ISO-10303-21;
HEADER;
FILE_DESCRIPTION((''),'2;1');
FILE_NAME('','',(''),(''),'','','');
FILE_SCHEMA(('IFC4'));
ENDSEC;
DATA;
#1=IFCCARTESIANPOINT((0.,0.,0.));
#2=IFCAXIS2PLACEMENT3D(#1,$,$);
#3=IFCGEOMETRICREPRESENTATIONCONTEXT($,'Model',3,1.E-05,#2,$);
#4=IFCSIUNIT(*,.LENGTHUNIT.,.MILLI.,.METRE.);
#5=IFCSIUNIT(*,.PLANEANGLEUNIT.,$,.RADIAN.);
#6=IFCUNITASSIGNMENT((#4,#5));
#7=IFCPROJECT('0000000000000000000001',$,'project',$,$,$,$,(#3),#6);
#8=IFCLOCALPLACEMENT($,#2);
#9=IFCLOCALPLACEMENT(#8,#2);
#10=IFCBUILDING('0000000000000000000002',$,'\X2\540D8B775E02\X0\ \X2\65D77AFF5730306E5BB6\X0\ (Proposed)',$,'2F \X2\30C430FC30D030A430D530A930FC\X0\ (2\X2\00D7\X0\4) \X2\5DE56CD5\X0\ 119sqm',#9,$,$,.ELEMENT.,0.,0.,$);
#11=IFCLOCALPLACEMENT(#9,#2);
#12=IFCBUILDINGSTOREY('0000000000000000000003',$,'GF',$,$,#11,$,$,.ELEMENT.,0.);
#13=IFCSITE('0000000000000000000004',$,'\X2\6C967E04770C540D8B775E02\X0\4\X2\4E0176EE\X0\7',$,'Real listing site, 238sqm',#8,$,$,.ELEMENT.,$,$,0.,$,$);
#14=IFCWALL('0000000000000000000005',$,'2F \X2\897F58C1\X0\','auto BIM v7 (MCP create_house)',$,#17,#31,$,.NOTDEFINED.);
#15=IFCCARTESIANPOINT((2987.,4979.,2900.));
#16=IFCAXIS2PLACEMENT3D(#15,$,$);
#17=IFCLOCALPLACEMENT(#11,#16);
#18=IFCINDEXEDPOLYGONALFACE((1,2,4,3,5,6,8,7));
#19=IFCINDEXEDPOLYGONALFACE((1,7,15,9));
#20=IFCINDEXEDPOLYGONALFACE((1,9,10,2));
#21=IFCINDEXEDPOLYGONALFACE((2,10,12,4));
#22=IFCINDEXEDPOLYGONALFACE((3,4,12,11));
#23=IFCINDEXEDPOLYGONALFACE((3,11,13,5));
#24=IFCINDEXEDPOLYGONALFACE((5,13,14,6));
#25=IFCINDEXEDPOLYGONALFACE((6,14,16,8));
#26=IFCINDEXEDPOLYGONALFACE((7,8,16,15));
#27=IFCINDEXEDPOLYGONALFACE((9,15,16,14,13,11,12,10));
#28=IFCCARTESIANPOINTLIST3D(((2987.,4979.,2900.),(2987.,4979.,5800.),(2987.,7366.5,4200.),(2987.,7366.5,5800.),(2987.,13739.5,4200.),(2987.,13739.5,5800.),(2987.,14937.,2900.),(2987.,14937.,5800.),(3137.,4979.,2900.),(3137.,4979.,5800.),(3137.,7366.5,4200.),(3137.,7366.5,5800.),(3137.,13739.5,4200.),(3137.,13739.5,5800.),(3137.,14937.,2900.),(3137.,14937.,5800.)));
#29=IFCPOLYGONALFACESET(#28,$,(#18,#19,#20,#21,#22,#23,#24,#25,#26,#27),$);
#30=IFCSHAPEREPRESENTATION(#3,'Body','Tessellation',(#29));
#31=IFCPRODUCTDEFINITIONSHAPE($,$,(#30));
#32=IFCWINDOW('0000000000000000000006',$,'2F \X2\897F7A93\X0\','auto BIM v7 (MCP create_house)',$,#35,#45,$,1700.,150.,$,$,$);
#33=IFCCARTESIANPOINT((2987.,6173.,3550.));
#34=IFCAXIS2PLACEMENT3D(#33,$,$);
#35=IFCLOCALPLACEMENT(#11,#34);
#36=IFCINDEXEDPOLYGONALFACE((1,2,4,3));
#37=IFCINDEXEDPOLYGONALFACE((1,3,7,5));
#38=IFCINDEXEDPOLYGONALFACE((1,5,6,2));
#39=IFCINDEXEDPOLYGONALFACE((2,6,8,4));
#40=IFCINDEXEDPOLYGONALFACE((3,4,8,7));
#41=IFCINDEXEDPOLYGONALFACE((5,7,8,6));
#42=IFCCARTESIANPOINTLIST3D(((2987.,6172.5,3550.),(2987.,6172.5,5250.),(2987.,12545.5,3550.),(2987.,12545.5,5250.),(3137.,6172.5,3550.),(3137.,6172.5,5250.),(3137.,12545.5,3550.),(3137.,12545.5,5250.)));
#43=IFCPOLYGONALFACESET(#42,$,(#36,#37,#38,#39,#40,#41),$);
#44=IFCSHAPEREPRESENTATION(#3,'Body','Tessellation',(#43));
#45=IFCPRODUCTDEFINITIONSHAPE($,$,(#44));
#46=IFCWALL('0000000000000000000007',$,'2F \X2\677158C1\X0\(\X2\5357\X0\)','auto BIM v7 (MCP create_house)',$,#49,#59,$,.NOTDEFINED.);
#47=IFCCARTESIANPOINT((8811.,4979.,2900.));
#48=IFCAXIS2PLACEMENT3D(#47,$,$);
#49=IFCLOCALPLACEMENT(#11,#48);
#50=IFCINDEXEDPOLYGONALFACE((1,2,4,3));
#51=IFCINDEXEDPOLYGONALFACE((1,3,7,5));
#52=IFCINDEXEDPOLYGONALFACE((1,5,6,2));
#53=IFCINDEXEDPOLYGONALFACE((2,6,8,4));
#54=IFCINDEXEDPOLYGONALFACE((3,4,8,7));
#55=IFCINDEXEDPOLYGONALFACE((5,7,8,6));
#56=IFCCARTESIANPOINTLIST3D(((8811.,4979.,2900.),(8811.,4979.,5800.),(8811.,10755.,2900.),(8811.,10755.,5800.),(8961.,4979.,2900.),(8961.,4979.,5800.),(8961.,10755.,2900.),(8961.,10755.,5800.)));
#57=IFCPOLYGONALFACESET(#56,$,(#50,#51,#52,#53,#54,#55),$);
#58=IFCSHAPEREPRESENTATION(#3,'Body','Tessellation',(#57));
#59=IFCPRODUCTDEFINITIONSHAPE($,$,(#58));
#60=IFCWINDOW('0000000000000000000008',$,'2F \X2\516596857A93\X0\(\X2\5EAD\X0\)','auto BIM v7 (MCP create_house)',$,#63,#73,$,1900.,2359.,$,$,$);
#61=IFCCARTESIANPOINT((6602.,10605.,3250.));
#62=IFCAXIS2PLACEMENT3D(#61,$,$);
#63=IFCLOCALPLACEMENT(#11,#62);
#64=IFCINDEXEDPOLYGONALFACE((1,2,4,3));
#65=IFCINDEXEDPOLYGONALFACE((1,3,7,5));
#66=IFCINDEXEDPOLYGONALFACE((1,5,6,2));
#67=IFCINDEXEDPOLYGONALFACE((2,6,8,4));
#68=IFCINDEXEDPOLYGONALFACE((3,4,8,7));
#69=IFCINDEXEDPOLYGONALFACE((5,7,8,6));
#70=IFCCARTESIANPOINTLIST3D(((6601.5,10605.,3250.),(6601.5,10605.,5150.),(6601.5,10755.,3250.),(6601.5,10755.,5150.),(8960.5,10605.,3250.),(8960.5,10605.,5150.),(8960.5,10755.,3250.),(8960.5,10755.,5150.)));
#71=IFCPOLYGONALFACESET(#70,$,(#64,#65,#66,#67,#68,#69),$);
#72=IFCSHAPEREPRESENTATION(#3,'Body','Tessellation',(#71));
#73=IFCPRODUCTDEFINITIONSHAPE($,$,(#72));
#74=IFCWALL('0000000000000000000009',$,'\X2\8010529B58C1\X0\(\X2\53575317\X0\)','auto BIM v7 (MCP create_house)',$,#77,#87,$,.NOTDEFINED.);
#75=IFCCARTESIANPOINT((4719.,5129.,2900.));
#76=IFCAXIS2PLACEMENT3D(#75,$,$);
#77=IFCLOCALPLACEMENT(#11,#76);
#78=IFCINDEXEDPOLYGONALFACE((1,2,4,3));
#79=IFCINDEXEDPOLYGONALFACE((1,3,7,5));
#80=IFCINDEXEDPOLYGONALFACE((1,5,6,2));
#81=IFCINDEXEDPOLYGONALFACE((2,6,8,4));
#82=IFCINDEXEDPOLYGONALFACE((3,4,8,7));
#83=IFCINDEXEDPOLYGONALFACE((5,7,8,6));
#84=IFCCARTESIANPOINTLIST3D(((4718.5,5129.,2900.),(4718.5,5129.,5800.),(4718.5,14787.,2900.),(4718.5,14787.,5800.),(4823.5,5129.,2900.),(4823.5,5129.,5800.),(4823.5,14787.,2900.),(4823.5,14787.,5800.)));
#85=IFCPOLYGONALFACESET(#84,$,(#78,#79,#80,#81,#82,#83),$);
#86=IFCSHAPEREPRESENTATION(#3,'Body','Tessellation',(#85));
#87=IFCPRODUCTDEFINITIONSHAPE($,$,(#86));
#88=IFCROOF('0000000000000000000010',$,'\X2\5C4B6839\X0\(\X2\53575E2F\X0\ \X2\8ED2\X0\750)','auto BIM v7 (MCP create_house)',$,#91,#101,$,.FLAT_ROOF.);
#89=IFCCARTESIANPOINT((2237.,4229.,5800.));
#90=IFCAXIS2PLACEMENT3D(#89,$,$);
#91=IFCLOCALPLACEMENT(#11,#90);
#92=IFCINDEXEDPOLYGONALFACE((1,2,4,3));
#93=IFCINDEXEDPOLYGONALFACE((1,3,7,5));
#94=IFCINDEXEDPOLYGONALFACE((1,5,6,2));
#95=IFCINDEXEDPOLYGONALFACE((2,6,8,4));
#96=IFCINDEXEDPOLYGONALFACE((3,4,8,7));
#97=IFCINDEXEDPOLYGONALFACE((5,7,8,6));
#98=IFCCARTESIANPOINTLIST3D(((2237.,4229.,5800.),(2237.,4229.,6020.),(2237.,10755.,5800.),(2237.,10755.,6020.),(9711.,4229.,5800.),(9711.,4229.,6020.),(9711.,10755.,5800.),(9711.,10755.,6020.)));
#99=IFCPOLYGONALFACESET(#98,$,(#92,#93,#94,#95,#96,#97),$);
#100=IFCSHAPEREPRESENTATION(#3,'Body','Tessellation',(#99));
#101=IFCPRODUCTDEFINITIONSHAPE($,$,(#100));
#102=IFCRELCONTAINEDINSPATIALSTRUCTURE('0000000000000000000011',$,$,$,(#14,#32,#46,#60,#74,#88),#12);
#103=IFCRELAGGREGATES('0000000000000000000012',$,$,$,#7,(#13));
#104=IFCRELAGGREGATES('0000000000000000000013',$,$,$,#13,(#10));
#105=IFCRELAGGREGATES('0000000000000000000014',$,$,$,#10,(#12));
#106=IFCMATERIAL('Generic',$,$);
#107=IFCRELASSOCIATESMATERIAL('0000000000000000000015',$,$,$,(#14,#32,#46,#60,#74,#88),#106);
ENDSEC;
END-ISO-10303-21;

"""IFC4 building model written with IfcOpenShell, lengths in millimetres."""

from ifc_helpers import new_model, si_unit, frame, frame_2d, origin, place, context, project, spatial, rectangle, extrude, material, element, fill, save


model = new_model("IFC4")

# Units and contexts
model_context = context("Model", 3, precision=1e-05, world=origin())
ifc_project = project(units=[si_unit("LENGTHUNIT", "METRE", prefix="MILLI"), si_unit("PLANEANGLEUNIT", "RADIAN")], contexts=[model_context])

# Site, building, storey
site_placement = place(None, origin())
site = spatial("IfcSite", under=ifc_project, at=site_placement, Name="沖縄県名護市4丁目7", ObjectType="Real listing site, 238sqm", CompositionType="ELEMENT", RefElevation=0.0)
building_placement = place(site_placement, origin())
building = spatial("IfcBuilding", under=site, at=building_placement, Name="名護市 旗竿地の家 (Proposed)", ObjectType="2F ツーバイフォー (2×4) 工法 119sqm", CompositionType="ELEMENT", ElevationOfRefHeight=0.0, ElevationOfTerrain=0.0)
storey_placement = place(building_placement, origin())
storey = spatial("IfcBuildingStorey", under=building, at=storey_placement, Name="GF", CompositionType="ELEMENT", Elevation=0.0)

# Shared definitions
ifc_material = material(Name="Generic")

# Walls, openings, windows
wall_1_placement = place(storey_placement, frame((2987.0, 4979.0, 2900.0)))
wall_1 = element("IfcWall", 1, at=wall_1_placement, inside=storey, material=ifc_material, Name="2F 西壁", Description="auto BIM v7 (MCP create_house)", PredefinedType="NOTDEFINED", context=model_context, shape_type="SweptSolid", body=[
    extrude(rectangle(XDim=150.0, YDim=9958.0, at=frame_2d((75.0, 4979.0))), frame((2987.0, 4979.0, 2900.0)), (0.0, 0.0, 1.0), 2900.0),
])
opening_1_placement = place(storey_placement, frame((2987.0, 6173.0, 3550.0)))
opening_1 = element("IfcOpeningElement", 2, at=opening_1_placement, cuts=wall_1, PredefinedType="NOTDEFINED", context=model_context, shape_type="SweptSolid", body=[
    extrude(rectangle(XDim=150.0, YDim=6373.0, at=frame_2d((75.0, 3186.0))), frame((2987.0, 6173.0, 3550.0)), (0.0, 0.0, 1.0), 1700.0),
])
window_1_placement = place(storey_placement, frame((2987.0, 6173.0, 3550.0)))
window_1 = element("IfcWindow", 3, at=window_1_placement, inside=storey, material=ifc_material, Name="2F 西窓", Description="auto BIM v7 (MCP create_house)", OverallHeight=1700.0, OverallWidth=150.0, context=model_context, shape_type="SweptSolid", body=[
    extrude(rectangle(XDim=150.0, YDim=6373.0, at=frame_2d((75.0, 3186.0))), frame((2987.0, 6173.0, 3550.0)), (0.0, 0.0, 1.0), 1700.0),
])
fill(opening_1, window_1)
wall_2_placement = place(storey_placement, frame((8811.0, 4979.0, 2900.0)))
wall_2 = element("IfcWall", 4, at=wall_2_placement, inside=storey, material=ifc_material, Name="2F 東壁(南)", Description="auto BIM v7 (MCP create_house)", PredefinedType="NOTDEFINED", context=model_context, shape_type="SweptSolid", body=[
    extrude(rectangle(XDim=150.0, YDim=5776.0, at=frame_2d((75.0, 2888.0))), frame((8811.0, 4979.0, 2900.0)), (0.0, 0.0, 1.0), 2900.0),
])
opening_2_placement = place(storey_placement, frame((6602.0, 10605.0, 3250.0)))
opening_2 = element("IfcOpeningElement", 5, at=opening_2_placement, cuts=wall_2, PredefinedType="NOTDEFINED", context=model_context, shape_type="SweptSolid", body=[
    extrude(rectangle(XDim=2359.0, YDim=150.0, at=frame_2d((1179.0, 75.0))), frame((6602.0, 10605.0, 3250.0)), (0.0, 0.0, 1.0), 1900.0),
])
window_2_placement = place(storey_placement, frame((6602.0, 10605.0, 3250.0)))
window_2 = element("IfcWindow", 6, at=window_2_placement, inside=storey, material=ifc_material, Name="2F 入隅窓(庭)", Description="auto BIM v7 (MCP create_house)", OverallHeight=1900.0, OverallWidth=2359.0, context=model_context, shape_type="SweptSolid", body=[
    extrude(rectangle(XDim=2359.0, YDim=150.0, at=frame_2d((1179.0, 75.0))), frame((6602.0, 10605.0, 3250.0)), (0.0, 0.0, 1.0), 1900.0),
])
fill(opening_2, window_2)

# Wall
wall_3_placement = place(storey_placement, frame((4719.0, 5129.0, 2900.0)))
element("IfcWall", 7, at=wall_3_placement, inside=storey, material=ifc_material, Name="耐力壁(南北)", Description="auto BIM v7 (MCP create_house)", PredefinedType="NOTDEFINED", context=model_context, shape_type="SweptSolid", body=[
    extrude(rectangle(XDim=105.0, YDim=9658.0, at=frame_2d((52.0, 4829.0))), frame((4719.0, 5129.0, 2900.0)), (0.0, 0.0, 1.0), 2900.0),
])

# Roof
for number, where, name in (
    (8, (2237.0, 4229.0, 5800.0), "屋根(南帯 軒750)"),
):
    element("IfcRoof", number, at=place(storey_placement, frame(where)), inside=storey, material=ifc_material, Name=name, Description="auto BIM v7 (MCP create_house)", PredefinedType="FLAT_ROOF", context=model_context, shape_type="SweptSolid", body=[
        extrude(rectangle(XDim=7474.0, YDim=6526.0, at=frame_2d((3737.0, 3263.0))), frame((2237.0, 4229.0, 5800.0)), (0.0, 0.0, 1.0), 220.0),
    ])

save(model, "model.ifc")
